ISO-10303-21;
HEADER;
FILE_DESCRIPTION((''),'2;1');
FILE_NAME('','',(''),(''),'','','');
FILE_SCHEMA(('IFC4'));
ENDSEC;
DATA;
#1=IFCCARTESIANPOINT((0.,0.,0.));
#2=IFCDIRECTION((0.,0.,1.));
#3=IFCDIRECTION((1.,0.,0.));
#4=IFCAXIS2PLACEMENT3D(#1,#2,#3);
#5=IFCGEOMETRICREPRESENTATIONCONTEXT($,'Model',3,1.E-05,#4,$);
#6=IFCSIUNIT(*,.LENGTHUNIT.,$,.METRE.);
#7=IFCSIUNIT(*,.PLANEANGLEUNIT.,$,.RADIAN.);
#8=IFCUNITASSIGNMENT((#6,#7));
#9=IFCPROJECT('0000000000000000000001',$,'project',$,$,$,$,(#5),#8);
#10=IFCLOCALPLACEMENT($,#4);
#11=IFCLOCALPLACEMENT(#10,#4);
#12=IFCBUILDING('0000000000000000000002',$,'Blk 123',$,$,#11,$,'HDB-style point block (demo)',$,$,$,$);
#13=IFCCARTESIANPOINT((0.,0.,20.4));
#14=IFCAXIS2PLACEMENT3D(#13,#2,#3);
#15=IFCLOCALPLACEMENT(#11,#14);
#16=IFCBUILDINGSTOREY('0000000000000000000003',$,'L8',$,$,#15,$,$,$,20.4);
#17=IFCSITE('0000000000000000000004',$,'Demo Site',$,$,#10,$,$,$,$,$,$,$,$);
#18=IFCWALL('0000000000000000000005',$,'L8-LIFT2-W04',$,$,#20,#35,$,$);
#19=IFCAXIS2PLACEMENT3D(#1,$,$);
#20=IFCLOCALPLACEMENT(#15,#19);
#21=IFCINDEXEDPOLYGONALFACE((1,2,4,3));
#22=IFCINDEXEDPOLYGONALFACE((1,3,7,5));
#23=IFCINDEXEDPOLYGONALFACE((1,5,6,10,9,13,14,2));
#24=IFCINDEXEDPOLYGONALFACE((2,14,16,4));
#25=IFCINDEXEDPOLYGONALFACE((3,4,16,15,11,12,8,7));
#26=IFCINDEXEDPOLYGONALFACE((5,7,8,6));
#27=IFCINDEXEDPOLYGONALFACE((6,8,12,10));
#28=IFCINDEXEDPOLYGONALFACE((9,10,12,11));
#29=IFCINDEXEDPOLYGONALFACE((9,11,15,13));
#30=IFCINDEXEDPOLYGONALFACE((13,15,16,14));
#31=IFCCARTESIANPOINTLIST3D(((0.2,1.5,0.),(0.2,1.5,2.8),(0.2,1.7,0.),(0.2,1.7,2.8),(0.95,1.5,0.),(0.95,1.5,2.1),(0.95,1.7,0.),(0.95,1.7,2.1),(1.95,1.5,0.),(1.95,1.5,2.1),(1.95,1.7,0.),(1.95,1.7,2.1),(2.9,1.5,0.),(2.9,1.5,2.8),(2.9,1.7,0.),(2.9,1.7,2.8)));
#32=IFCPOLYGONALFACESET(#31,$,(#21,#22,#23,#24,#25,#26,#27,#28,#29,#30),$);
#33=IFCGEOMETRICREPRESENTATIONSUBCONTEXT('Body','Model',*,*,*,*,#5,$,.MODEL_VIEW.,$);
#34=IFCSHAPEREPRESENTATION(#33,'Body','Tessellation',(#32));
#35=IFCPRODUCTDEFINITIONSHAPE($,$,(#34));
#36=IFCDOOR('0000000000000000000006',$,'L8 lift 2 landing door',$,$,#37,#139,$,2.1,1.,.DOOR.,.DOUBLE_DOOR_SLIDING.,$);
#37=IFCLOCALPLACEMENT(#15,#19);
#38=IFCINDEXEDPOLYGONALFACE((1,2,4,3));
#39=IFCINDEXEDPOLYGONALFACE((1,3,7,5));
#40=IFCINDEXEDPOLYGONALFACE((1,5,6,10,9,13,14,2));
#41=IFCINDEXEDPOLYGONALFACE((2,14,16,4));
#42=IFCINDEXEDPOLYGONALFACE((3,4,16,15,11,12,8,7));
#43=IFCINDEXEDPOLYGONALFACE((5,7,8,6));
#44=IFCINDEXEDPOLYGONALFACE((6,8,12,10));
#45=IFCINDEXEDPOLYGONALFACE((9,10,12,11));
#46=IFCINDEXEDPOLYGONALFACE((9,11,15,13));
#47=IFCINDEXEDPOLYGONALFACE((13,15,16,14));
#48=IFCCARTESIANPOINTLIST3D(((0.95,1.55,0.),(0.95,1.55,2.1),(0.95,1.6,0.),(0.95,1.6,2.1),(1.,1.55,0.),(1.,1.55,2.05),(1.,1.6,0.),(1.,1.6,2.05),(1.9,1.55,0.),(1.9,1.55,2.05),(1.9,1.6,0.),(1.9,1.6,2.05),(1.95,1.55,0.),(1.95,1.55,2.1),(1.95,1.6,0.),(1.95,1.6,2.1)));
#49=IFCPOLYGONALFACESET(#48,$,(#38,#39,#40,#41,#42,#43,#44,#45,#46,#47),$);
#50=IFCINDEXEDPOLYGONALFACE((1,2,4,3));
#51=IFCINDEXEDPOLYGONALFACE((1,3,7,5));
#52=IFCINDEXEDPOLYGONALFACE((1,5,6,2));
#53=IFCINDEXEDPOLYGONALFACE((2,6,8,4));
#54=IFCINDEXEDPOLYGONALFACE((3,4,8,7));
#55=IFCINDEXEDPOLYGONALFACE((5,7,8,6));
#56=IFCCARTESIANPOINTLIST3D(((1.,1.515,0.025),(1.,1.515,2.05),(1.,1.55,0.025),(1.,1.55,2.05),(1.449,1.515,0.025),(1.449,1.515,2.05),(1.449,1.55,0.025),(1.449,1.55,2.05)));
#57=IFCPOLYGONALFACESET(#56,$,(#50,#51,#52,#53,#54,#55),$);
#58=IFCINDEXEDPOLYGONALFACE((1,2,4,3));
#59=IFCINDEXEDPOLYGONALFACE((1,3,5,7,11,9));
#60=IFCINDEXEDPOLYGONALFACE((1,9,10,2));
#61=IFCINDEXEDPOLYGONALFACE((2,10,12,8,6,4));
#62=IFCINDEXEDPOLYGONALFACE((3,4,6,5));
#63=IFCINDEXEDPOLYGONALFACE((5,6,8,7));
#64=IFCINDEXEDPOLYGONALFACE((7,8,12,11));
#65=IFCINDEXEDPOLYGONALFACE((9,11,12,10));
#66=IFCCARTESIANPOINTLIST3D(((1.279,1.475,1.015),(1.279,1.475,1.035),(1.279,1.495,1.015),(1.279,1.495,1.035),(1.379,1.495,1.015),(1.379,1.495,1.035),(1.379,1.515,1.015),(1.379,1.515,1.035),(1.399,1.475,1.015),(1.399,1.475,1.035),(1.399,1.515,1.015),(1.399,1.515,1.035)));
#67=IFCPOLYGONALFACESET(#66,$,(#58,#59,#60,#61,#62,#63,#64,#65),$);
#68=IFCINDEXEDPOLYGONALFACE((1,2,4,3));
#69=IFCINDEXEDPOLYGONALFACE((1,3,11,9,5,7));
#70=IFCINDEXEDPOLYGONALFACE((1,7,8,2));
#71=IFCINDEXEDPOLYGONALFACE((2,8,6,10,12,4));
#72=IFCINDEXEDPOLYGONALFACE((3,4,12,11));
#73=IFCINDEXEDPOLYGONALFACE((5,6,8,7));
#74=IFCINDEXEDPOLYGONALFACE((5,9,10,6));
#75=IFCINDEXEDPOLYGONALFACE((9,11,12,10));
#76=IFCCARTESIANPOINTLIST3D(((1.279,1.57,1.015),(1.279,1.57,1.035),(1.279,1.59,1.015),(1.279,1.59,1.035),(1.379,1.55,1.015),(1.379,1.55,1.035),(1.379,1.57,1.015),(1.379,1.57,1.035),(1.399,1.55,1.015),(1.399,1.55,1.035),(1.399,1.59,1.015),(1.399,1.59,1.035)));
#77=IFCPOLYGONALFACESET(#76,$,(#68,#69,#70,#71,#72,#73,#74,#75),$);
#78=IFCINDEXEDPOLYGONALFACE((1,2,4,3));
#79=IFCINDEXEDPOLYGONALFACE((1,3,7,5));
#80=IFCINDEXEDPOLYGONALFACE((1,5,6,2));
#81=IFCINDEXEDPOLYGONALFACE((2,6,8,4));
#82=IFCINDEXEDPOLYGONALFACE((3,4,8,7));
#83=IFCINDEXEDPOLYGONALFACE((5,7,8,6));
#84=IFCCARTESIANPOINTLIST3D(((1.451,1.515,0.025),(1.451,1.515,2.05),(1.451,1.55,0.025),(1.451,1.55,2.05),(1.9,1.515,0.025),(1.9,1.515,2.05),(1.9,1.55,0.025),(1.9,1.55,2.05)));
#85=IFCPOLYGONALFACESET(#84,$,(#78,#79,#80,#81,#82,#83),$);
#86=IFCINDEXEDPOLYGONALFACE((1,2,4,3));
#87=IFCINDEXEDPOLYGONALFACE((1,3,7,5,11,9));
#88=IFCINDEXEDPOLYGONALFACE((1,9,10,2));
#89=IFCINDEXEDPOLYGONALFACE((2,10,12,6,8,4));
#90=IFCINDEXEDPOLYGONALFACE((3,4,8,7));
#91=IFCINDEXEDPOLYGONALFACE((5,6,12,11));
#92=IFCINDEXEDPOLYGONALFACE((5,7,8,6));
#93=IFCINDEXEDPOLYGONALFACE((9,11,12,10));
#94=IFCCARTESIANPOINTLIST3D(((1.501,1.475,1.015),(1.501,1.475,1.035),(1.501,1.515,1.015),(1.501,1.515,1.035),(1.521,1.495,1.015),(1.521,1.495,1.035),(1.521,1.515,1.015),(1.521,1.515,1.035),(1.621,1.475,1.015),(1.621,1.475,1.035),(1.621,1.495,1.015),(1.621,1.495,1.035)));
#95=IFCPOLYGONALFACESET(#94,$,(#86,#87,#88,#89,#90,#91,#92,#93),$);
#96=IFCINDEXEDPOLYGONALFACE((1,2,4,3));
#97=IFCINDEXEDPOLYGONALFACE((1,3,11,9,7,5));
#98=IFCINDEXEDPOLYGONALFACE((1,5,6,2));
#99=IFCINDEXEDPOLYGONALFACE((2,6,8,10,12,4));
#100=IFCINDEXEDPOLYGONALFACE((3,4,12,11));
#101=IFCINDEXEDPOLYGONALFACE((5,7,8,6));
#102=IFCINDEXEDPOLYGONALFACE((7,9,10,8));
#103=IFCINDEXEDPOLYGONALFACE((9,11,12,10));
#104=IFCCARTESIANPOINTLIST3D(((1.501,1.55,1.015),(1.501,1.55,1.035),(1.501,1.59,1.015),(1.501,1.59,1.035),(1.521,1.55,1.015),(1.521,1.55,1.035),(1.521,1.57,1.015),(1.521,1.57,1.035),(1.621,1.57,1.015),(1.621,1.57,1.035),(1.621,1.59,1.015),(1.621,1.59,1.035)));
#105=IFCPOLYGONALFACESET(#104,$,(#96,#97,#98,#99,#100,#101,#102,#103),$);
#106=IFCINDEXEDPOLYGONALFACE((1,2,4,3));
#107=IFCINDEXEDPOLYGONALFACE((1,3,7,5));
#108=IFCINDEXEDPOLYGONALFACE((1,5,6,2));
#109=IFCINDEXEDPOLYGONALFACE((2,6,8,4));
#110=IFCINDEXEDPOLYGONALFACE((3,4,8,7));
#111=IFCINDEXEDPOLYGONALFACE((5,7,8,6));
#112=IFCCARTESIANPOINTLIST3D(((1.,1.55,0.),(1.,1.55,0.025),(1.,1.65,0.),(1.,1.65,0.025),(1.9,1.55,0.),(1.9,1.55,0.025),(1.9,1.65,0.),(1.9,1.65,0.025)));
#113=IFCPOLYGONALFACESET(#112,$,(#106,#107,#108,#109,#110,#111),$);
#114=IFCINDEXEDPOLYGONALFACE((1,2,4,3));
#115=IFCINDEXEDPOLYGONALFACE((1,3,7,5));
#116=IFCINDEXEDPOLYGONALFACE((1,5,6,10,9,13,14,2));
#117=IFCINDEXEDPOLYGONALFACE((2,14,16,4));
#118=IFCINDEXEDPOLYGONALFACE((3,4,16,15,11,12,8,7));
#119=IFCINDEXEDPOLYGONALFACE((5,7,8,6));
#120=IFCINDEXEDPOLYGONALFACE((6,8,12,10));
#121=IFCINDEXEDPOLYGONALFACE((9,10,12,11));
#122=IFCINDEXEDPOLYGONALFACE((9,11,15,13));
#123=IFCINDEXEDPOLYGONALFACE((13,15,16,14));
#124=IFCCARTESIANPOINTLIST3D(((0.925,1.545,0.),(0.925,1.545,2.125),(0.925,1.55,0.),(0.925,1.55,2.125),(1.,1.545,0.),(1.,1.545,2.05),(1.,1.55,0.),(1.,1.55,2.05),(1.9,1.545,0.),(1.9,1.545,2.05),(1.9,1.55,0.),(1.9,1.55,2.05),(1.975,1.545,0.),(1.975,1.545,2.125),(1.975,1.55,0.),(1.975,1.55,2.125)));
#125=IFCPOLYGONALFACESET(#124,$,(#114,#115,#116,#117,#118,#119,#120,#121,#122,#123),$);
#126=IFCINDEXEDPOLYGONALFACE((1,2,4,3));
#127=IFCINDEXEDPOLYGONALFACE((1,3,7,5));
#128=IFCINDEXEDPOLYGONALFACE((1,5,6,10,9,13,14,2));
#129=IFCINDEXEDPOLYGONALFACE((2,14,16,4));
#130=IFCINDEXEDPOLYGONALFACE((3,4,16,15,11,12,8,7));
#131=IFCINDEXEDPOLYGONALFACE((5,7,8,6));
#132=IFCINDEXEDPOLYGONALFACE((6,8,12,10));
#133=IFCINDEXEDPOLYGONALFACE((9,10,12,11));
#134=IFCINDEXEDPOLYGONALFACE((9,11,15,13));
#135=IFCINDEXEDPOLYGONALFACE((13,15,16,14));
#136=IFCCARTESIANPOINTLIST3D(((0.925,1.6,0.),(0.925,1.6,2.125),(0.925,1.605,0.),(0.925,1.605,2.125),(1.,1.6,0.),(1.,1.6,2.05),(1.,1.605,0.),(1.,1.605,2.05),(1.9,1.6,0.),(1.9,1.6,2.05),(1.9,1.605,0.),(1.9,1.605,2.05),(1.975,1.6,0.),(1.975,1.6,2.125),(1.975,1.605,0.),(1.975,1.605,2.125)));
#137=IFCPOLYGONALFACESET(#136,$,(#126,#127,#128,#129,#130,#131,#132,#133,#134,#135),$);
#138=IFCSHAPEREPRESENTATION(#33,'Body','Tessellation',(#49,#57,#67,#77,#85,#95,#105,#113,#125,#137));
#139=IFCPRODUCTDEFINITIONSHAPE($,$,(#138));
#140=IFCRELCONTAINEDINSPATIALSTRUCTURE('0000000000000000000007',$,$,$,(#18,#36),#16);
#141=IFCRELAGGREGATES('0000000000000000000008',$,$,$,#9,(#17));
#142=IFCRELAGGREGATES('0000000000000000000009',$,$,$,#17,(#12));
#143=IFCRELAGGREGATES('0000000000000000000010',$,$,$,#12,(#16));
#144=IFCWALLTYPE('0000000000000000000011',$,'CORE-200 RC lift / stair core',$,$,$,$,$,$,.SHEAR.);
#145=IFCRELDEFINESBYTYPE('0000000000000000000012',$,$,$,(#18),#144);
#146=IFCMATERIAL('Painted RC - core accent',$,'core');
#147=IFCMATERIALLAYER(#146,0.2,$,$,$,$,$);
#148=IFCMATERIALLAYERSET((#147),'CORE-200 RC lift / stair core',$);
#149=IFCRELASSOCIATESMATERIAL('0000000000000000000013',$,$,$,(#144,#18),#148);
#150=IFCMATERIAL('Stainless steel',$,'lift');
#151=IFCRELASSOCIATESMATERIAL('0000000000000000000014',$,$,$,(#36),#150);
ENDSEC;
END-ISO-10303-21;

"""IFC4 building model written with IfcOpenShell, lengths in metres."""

from ifc_helpers import new_model, si_unit, frame, origin_with_axes, place, context, subcontext, project, spatial, line, indexed_curve, outline, extrude, material, layer, layer_set, layer_usage, type_object, element, fill, save


model = new_model("IFC4")

# Units and contexts
model_context = context("Model", 3, precision=1e-05, world=origin_with_axes())
body_context = subcontext(model_context, "Body", "Model", "MODEL_VIEW")
ifc_project = project(units=[si_unit("LENGTHUNIT", "METRE"), si_unit("PLANEANGLEUNIT", "RADIAN")], contexts=[model_context])

# Site, building, storey
site_placement = place(None, origin_with_axes())
site = spatial("IfcSite", under=ifc_project, at=site_placement, Name="Demo Site")
building_placement = place(site_placement, origin_with_axes())
building = spatial("IfcBuilding", under=site, at=building_placement, Name="Blk 123", LongName="HDB-style point block (demo)")
storey_placement = place(building_placement, frame((0.0, 0.0, 20.4), z_axis=(0.0, 0.0, 1.0), x_axis=(1.0, 0.0, 0.0)))
storey = spatial("IfcBuildingStorey", under=building, at=storey_placement, Name="L8", Elevation=20.4)

# Shared definitions
ifc_material_1 = material(Name="Painted RC - core accent", Category="core")
ifc_layer_1 = layer(ifc_material_1, 0.2)
ifc_layer_set_1 = layer_set([ifc_layer_1], Name="CORE-200 RC lift / stair core")
ifc_layer_usage_1 = layer_usage(ifc_layer_set_1, "AXIS2", "POSITIVE", 0.0)
wall_type_1 = type_object("IfcWallType", Name="CORE-200 RC lift / stair core", PredefinedType="SHEAR", material=ifc_layer_set_1)

# Wall, opening, door
wall_1_placement = place(storey_placement, frame((0.2, 1.5, 0.0), z_axis=(0.0, 0.0, 1.0), x_axis=(1.0, 0.0, 0.0)))
wall_1 = element("IfcWall", 1, at=wall_1_placement, inside=storey, type_object=wall_type_1, material=ifc_layer_usage_1, Name="L8-LIFT2-W04", context=body_context, shape_type="SweptSolid", body=[
    extrude(outline(indexed_curve([(0.0, 0.0), (0.0, 0.2), (2.7, 0.2), (2.7, 0.0), (0.0, 0.0)], self_intersect=False)), origin_with_axes(), (0.0, 0.0, 1.0), 2.8),
])
opening_1_placement = place(wall_1_placement, frame((0.75, -0.1, 0.0), z_axis=(0.0, 0.0, 1.0), x_axis=(1.0, 0.0, 0.0)))
opening_1 = element("IfcOpeningElement", 2, at=opening_1_placement, cuts=wall_1, context=body_context, shape_type="SweptSolid", body=[
    extrude(outline(indexed_curve([(0.0, 0.0), (0.0, 0.4), (1.0, 0.4), (1.0, 0.0), (0.0, 0.0)], self_intersect=False)), origin_with_axes(), (0.0, 0.0, 1.0), 2.1),
])
ifc_material_2 = material(Name="Stainless steel", Category="lift")
door_1_placement = place(opening_1_placement, frame((0.0, 0.15, 0.0), z_axis=(0.0, 0.0, 1.0), x_axis=(1.0, 0.0, 0.0)))
door_1 = element("IfcDoor", 3, at=door_1_placement, inside=storey, material=ifc_material_2, Name="L8 lift 2 landing door", OperationType="DOUBLE_DOOR_SLIDING", OverallHeight=2.1, OverallWidth=1.0, PredefinedType="DOOR", context=body_context, shape_type="SweptSolid", body=[
    extrude(outline(indexed_curve([(0.0, 0.0), (0.0, 2.1), (1.0, 2.1), (1.0, 0.0), (0.95, 0.0), (0.95, 2.05), (0.05, 2.05), (0.05, 0.0)], segments=[line(1, 2, 3, 4, 5, 6, 7, 8, 1)])), frame((0.0, 0.0, 0.0), z_axis=(0.0, -1.0, 0.0), x_axis=(1.0, 0.0, 0.0)), (0.0, 0.0, -1.0), 0.05),
    extrude(outline(indexed_curve([(0.0, 0.0), (0.449, 0.0), (0.449, 0.035), (0.0, 0.035)], segments=[line(1, 2, 3, 4, 1)])), frame((0.05, -0.035, 0.025), z_axis=(0.0, 0.0, 1.0), x_axis=(1.0, 0.0, 0.0)), (0.0, 0.0, 1.0), 2.025),
    extrude(outline(indexed_curve([(0.0, 0.0), (0.0, -0.04), (-0.12, -0.04), (-0.12, -0.02), (-0.02, -0.02), (-0.02, 0.0)], segments=[line(1, 2, 3, 4, 5, 6, 1)])), frame((0.449, -0.035, 1.015), z_axis=(0.0, 0.0, 1.0), x_axis=(1.0, 0.0, 0.0)), (0.0, 0.0, 1.0), 0.02),
    extrude(outline(indexed_curve([(0.0, 0.0), (0.0, 0.04), (-0.12, 0.04), (-0.12, 0.02), (-0.02, 0.02), (-0.02, 0.0)], segments=[line(1, 2, 3, 4, 5, 6, 1)])), frame((0.449, 0.0, 1.015), z_axis=(0.0, 0.0, 1.0), x_axis=(1.0, 0.0, 0.0)), (0.0, 0.0, 1.0), 0.02),
    extrude(outline(indexed_curve([(0.0, 0.0), (-0.449, 0.0), (-0.449, 0.035), (0.0, 0.035)], segments=[line(1, 2, 3, 4, 1)])), frame((0.95, -0.035, 0.025), z_axis=(0.0, 0.0, 1.0), x_axis=(1.0, 0.0, 0.0)), (0.0, 0.0, 1.0), 2.025),
    extrude(outline(indexed_curve([(0.0, 0.0), (0.0, -0.04), (0.12, -0.04), (0.12, -0.02), (0.02, -0.02), (0.02, 0.0)], segments=[line(1, 2, 3, 4, 5, 6, 1)])), frame((0.551, -0.035, 1.015), z_axis=(0.0, 0.0, 1.0), x_axis=(1.0, 0.0, 0.0)), (0.0, 0.0, 1.0), 0.02),
    extrude(outline(indexed_curve([(0.0, 0.0), (0.0, 0.04), (0.12, 0.04), (0.12, 0.02), (0.02, 0.02), (0.02, 0.0)], segments=[line(1, 2, 3, 4, 5, 6, 1)])), frame((0.551, 0.0, 1.015), z_axis=(0.0, 0.0, 1.0), x_axis=(1.0, 0.0, 0.0)), (0.0, 0.0, 1.0), 0.02),
    extrude(outline(indexed_curve([(0.0, 0.0), (0.9, 0.0), (0.9, 0.1), (0.0, 0.1)], segments=[line(1, 2, 3, 4, 1)])), frame((0.05, 0.0, 0.0), z_axis=(0.0, 0.0, 1.0), x_axis=(1.0, 0.0, 0.0)), (0.0, 0.0, 1.0), 0.025),
    extrude(outline(indexed_curve([(0.0, 0.0), (0.0, 2.125), (1.05, 2.125), (1.05, 0.0), (0.975, 0.0), (0.975, 2.05), (0.075, 2.05), (0.075, 0.0)], segments=[line(1, 2, 3, 4, 5, 6, 7, 8, 1)])), frame((-0.025, -0.005, 0.0), z_axis=(0.0, -1.0, 0.0), x_axis=(1.0, 0.0, 0.0)), (0.0, 0.0, -1.0), 0.005),
    extrude(outline(indexed_curve([(0.0, 0.0), (0.0, 2.125), (1.05, 2.125), (1.05, 0.0), (0.975, 0.0), (0.975, 2.05), (0.075, 2.05), (0.075, 0.0)], segments=[line(1, 2, 3, 4, 5, 6, 7, 8, 1)])), frame((-0.025, 0.05, 0.0), z_axis=(0.0, -1.0, 0.0), x_axis=(1.0, 0.0, 0.0)), (0.0, 0.0, -1.0), 0.005),
])
fill(opening_1, door_1)

save(model, "model.ifc")
